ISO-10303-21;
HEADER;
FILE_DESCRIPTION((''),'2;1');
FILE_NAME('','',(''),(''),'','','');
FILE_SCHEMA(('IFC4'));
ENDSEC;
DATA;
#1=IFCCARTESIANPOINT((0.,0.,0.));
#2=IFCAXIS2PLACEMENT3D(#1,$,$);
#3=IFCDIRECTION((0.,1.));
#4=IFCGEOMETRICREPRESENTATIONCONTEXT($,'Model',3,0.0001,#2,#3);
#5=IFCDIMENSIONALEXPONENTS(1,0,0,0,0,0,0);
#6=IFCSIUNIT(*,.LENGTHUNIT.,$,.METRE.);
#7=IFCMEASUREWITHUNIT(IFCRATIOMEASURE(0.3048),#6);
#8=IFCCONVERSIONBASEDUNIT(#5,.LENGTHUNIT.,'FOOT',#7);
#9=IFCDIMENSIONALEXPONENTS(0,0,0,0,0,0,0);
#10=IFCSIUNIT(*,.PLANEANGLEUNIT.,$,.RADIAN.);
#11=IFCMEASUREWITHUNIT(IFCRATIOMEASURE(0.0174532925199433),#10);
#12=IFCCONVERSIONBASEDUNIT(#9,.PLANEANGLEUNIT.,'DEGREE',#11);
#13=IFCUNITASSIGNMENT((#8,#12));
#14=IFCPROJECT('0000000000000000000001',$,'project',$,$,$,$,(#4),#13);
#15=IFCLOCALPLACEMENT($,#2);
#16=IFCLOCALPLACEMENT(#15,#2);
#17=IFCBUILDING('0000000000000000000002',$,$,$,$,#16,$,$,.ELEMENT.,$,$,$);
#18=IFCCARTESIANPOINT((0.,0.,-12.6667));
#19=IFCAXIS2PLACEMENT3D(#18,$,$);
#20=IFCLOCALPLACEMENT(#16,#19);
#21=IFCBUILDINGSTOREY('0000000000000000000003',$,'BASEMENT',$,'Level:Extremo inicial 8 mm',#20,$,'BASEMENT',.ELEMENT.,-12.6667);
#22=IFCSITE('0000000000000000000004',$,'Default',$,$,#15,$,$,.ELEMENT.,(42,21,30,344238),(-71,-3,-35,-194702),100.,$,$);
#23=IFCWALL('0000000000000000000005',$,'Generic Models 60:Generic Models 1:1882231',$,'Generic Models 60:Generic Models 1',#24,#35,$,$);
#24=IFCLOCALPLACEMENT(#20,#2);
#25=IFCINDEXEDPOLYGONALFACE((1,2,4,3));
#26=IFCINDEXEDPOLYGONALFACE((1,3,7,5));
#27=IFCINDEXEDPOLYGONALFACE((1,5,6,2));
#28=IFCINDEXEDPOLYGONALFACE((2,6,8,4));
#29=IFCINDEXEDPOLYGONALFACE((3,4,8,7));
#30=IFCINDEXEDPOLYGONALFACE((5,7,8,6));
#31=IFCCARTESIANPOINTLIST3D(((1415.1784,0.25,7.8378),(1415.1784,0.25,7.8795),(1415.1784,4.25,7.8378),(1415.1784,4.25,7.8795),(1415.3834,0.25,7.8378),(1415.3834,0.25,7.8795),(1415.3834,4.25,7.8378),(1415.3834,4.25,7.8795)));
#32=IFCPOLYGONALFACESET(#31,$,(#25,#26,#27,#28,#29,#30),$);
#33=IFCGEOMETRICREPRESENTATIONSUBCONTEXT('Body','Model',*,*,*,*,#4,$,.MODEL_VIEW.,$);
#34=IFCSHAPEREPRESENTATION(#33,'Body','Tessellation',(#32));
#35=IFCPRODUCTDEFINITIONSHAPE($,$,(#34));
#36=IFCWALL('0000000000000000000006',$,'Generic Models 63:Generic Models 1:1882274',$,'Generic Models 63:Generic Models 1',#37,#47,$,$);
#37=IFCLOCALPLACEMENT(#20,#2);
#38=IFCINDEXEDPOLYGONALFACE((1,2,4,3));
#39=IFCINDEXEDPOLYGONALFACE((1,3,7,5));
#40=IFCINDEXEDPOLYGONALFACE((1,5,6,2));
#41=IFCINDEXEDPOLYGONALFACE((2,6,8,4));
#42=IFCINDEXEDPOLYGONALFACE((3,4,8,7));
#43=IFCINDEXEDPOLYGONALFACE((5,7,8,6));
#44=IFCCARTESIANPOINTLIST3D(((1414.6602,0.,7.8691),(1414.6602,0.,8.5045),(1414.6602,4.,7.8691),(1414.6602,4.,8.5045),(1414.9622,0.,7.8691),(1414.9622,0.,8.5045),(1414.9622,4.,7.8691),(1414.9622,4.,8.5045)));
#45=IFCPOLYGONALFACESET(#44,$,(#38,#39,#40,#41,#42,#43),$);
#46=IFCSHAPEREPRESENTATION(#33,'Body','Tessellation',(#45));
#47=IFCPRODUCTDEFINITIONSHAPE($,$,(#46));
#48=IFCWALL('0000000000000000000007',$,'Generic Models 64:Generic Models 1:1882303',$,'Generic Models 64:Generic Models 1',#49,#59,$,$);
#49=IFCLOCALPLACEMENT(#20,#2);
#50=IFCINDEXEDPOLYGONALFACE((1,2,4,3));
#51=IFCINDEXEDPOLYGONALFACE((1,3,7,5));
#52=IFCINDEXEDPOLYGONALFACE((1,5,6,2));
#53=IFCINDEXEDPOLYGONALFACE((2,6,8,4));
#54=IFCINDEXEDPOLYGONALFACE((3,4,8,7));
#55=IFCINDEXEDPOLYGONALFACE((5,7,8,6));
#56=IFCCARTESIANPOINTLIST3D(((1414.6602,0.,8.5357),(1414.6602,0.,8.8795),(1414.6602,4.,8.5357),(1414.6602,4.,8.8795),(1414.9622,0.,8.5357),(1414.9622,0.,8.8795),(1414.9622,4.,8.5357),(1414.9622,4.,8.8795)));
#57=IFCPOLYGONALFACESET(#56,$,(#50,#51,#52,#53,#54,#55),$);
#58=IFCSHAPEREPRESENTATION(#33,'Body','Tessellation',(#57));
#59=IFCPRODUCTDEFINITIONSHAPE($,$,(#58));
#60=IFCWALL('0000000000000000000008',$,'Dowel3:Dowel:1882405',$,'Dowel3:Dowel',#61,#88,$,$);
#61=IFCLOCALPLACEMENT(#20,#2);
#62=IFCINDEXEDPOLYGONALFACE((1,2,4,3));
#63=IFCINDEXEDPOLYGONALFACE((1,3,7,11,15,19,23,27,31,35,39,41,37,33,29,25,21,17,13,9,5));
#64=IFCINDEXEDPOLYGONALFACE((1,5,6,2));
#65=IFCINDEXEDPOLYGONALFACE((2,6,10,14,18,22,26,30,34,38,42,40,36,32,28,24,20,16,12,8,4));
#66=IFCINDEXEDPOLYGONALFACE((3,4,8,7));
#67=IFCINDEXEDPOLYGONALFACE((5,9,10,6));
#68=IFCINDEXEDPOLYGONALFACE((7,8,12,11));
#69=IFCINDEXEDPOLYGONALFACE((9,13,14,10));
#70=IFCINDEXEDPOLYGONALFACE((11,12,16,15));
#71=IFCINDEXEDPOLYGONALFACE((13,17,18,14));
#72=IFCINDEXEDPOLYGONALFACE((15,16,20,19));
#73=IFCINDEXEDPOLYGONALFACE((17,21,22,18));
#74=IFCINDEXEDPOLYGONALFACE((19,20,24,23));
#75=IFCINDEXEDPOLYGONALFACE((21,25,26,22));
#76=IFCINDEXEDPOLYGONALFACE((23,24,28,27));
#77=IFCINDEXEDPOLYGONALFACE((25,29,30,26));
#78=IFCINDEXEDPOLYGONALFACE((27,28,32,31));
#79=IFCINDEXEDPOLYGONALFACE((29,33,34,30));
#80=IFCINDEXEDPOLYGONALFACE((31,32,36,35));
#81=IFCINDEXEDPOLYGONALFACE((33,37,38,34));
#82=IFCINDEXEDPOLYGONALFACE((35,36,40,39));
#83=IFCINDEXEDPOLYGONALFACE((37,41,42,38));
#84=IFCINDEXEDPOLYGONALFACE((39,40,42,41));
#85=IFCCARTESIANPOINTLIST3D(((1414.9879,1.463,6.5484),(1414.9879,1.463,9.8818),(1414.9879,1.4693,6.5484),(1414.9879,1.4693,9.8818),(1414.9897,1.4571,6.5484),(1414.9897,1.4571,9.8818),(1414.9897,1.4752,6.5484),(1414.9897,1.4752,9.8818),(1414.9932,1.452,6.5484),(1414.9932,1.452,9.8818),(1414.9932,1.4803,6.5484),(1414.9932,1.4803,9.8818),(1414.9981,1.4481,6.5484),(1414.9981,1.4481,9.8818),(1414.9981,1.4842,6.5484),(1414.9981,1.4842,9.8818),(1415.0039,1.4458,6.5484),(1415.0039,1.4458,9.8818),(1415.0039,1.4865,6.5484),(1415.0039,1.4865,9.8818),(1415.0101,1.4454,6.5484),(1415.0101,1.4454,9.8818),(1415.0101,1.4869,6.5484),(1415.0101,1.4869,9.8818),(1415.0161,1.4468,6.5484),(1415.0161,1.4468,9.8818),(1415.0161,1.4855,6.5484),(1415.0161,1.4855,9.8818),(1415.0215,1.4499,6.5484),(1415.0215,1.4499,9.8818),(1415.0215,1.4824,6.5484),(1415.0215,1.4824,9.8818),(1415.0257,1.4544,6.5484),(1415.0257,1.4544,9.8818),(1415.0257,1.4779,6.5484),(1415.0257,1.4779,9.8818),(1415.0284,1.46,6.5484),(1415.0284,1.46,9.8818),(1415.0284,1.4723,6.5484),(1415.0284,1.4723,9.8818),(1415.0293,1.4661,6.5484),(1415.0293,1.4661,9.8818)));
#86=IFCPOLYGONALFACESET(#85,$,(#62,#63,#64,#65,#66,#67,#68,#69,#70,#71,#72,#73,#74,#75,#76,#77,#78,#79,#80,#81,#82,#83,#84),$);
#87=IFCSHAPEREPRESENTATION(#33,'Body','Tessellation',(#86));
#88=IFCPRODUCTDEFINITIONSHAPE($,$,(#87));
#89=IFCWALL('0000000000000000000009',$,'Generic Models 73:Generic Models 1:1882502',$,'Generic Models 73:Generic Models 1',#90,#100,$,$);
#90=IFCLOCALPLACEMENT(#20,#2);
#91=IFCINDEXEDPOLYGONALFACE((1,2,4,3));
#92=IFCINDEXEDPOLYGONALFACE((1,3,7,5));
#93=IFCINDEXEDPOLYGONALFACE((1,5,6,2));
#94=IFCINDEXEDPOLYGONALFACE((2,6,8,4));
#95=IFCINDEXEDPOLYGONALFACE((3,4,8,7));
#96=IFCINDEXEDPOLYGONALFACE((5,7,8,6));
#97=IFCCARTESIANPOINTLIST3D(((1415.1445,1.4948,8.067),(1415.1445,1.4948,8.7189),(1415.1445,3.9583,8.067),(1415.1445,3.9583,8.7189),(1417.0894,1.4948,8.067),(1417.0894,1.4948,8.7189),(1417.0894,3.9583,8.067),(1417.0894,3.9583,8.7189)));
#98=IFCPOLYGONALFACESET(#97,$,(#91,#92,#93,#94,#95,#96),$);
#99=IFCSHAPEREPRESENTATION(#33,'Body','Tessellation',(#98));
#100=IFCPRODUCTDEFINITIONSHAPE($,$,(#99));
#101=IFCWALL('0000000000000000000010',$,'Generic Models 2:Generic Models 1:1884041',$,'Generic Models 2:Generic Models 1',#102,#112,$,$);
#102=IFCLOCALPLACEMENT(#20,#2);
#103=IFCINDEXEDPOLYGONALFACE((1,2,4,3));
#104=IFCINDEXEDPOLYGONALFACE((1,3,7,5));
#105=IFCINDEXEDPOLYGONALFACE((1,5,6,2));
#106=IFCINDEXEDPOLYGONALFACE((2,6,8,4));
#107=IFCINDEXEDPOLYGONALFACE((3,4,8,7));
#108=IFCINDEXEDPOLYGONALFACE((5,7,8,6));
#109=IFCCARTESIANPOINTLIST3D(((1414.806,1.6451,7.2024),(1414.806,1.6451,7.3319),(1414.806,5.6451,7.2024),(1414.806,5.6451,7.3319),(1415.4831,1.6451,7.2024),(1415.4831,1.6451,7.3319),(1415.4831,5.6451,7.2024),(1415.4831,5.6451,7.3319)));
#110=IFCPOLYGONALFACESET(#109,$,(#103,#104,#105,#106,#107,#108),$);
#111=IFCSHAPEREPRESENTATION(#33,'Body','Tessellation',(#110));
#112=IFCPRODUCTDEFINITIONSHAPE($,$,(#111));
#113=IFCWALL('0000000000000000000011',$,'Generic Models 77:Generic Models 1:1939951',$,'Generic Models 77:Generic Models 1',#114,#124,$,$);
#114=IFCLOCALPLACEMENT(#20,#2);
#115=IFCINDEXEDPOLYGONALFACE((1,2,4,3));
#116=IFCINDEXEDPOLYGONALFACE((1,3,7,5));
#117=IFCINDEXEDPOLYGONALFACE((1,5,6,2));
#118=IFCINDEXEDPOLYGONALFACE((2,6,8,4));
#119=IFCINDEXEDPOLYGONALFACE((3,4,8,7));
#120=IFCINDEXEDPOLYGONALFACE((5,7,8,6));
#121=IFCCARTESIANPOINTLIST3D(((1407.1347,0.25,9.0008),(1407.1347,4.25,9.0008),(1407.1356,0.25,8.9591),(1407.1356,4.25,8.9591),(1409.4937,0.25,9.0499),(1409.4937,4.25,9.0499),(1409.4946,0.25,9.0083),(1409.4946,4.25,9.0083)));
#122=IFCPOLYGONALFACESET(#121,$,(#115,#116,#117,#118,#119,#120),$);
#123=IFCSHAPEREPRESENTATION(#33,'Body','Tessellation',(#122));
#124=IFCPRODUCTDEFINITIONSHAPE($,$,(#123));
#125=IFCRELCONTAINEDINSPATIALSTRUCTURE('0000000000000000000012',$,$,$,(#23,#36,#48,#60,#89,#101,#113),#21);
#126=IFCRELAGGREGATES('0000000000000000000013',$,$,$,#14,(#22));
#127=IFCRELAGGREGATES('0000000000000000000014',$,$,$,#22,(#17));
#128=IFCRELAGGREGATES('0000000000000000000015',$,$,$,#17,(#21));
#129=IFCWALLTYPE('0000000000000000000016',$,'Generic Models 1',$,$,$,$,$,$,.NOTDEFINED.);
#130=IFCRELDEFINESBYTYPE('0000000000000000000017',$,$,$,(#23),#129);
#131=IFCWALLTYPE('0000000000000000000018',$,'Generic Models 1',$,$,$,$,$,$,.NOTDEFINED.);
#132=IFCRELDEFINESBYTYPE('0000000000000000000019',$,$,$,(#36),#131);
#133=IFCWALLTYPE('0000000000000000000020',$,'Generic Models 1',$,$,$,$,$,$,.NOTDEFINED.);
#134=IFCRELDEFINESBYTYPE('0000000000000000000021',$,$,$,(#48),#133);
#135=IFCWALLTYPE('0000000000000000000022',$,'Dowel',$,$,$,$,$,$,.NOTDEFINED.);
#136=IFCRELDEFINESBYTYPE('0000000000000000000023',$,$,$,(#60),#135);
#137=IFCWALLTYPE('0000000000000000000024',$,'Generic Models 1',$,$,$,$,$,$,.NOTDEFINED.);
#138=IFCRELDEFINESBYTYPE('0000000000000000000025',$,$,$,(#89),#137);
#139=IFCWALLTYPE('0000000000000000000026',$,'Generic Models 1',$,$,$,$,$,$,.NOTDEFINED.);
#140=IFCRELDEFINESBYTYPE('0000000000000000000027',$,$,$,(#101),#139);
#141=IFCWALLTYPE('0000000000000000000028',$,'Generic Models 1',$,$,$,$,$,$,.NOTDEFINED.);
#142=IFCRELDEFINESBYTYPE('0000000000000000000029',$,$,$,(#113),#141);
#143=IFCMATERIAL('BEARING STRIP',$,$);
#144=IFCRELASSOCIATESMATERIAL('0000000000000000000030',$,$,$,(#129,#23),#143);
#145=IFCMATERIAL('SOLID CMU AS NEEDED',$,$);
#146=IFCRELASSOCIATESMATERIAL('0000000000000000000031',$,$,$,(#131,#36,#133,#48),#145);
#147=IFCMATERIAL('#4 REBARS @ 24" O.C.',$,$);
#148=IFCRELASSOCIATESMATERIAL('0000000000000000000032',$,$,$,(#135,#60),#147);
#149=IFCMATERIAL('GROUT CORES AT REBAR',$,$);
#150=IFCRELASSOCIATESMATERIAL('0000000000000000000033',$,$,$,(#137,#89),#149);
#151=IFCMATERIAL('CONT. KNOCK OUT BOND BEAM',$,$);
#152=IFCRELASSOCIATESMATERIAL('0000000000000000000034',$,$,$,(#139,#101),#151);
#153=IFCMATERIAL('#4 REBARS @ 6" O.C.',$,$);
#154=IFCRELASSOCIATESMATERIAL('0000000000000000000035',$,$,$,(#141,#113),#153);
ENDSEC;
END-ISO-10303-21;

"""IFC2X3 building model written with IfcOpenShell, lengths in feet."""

from ifc_helpers import new_model, entity, si_unit, converted_unit, direction, frame, frame_2d, origin, origin_2d_with_axis, place, context, subcontext, project, spatial, rectangle, circle, extrude, material, type_object, element, save


model = new_model("IFC2X3")

# Units and contexts
model_context = context("Model", 3, precision=0.0001, world=origin(), true_north=direction((0.0, 1.0)))
body_context = subcontext(model_context, "Body", "Model", "MODEL_VIEW")
ifc_project = project(units=[converted_unit("LENGTHUNIT", "FOOT", entity("IfcRatioMeasure", 0.3048), si_unit("LENGTHUNIT", "METRE"), dimensions=[1, 0, 0, 0, 0, 0, 0]), converted_unit("PLANEANGLEUNIT", "DEGREE", entity("IfcRatioMeasure", 0.0174532925199433), si_unit("PLANEANGLEUNIT", "RADIAN"), dimensions=[0, 0, 0, 0, 0, 0, 0])], contexts=[model_context])

# Site, building, storey
site_placement = place(None, origin())
site = spatial("IfcSite", under=ifc_project, at=site_placement, Name="Default", CompositionType="ELEMENT", RefLatitude=(42, 21, 30, 344238), RefLongitude=(-71, -3, -35, -194702), RefElevation=100.0)
building_placement = place(site_placement, origin())
building = spatial("IfcBuilding", under=site, at=building_placement, CompositionType="ELEMENT")
storey_placement = place(building_placement, frame((0.0, 0.0, -12.6667)))
storey = spatial("IfcBuildingStorey", under=building, at=storey_placement, Name="BASEMENT", ObjectType="Level:Extremo inicial 8 mm", LongName="BASEMENT", CompositionType="ELEMENT", Elevation=-12.6667)

# Wall
ifc_material_1 = material(Name="BEARING STRIP")
wall_type_1 = type_object("IfcWallType", Name="Generic Models 1", PredefinedType="NOTDEFINED", material=ifc_material_1)
wall_1_placement = place(storey_placement, frame((1415.1784, 0.25, 7.8378), z_axis=(0.0, 0.0, 1.0), x_axis=(0.0, 1.0, 0.0)))
element("IfcWall", 1, at=wall_1_placement, inside=storey, type_object=wall_type_1, material=ifc_material_1, Name="Generic Models 60:Generic Models 1:1882231", ObjectType="Generic Models 60:Generic Models 1", context=body_context, shape_type="SweptSolid", body=[
    extrude(rectangle(XDim=4.0, YDim=0.205, at=frame_2d((0.0, 0.0), x_axis=(1.0, 0.0))), frame((2.0, -0.1025, 0.0)), (0.0, 0.0, 1.0), 0.0417),
])

# Walls
ifc_material_2 = material(Name="SOLID CMU AS NEEDED")
wall_type_2 = type_object("IfcWallType", Name="Generic Models 1", PredefinedType="NOTDEFINED", material=ifc_material_2)
wall_2_placement = place(storey_placement, frame((1414.6602, 0.0, 7.8691), z_axis=(0.0, 0.0, 1.0), x_axis=(0.0, 1.0, 0.0)))
element("IfcWall", 2, at=wall_2_placement, inside=storey, type_object=wall_type_2, material=ifc_material_2, Name="Generic Models 63:Generic Models 1:1882274", ObjectType="Generic Models 63:Generic Models 1", context=body_context, shape_type="SweptSolid", body=[
    extrude(rectangle(XDim=4.0, YDim=0.3021, at=frame_2d((0.0, 0.0), x_axis=(1.0, 0.0))), frame((2.0, -0.151, 0.0), z_axis=(0.0, 0.0, 1.0), x_axis=(-1.0, 0.0, 0.0)), (0.0, 0.0, 1.0), 0.6354),
])
wall_type_3 = type_object("IfcWallType", Name="Generic Models 1", PredefinedType="NOTDEFINED", material=ifc_material_2)
wall_3_placement = place(storey_placement, frame((1414.6602, 0.0, 8.5357), z_axis=(0.0, 0.0, 1.0), x_axis=(0.0, 1.0, 0.0)))
element("IfcWall", 3, at=wall_3_placement, inside=storey, type_object=wall_type_3, material=ifc_material_2, Name="Generic Models 64:Generic Models 1:1882303", ObjectType="Generic Models 64:Generic Models 1", context=body_context, shape_type="SweptSolid", body=[
    extrude(rectangle(XDim=4.0, YDim=0.3021, at=frame_2d((0.0, 0.0), x_axis=(1.0, 0.0))), frame((2.0, -0.151, 0.0), z_axis=(0.0, 0.0, 1.0), x_axis=(-1.0, 0.0, 0.0)), (0.0, 0.0, 1.0), 0.3437),
])

# Wall
ifc_material_3 = material(Name="#4 REBARS @ 24\" O.C.")
wall_type_4 = type_object("IfcWallType", Name="Dowel", PredefinedType="NOTDEFINED", material=ifc_material_3)
wall_4_placement = place(storey_placement, frame((1414.9877, 1.4453, 6.5484), z_axis=(0.0, 0.0, 1.0), x_axis=(0.0, 1.0, 0.0)))
element("IfcWall", 4, at=wall_4_placement, inside=storey, type_object=wall_type_4, material=ifc_material_3, Name="Dowel3:Dowel:1882405", ObjectType="Dowel3:Dowel", context=body_context, shape_type="SweptSolid", body=[
    extrude(circle(Radius=0.0208, at=origin_2d_with_axis()), frame((0.0208, -0.0208, 0.0), z_axis=(0.0, 0.0, 1.0), x_axis=(0.0, -1.0, 0.0)), (0.0, 0.0, 1.0), 3.3333),
])

# Shared definitions
ifc_material_4 = material(Name="CONT. KNOCK OUT BOND BEAM")

# Walls
ifc_material_5 = material(Name="GROUT CORES AT REBAR")
wall_type_5 = type_object("IfcWallType", Name="Generic Models 1", PredefinedType="NOTDEFINED", material=ifc_material_5)
wall_5_placement = place(storey_placement, frame((1415.1445, 1.4948, 8.067), z_axis=(0.0, 0.0, 1.0), x_axis=(0.0, 1.0, 0.0)))
element("IfcWall", 5, at=wall_5_placement, inside=storey, type_object=wall_type_5, material=ifc_material_5, Name="Generic Models 73:Generic Models 1:1882502", ObjectType="Generic Models 73:Generic Models 1", context=body_context, shape_type="SweptSolid", body=[
    extrude(rectangle(XDim=2.4635, YDim=1.9448, at=frame_2d((0.0, 0.0), x_axis=(1.0, 0.0))), frame((1.2318, -0.9724, 0.0)), (0.0, 0.0, 1.0), 0.6519),
])
wall_type_6 = type_object("IfcWallType", Name="Generic Models 1", PredefinedType="NOTDEFINED", material=ifc_material_4)
wall_6_placement = place(storey_placement, frame((1414.806, 1.6451, 7.2024), z_axis=(0.0, 0.0, 1.0), x_axis=(0.0, 1.0, 0.0)))
element("IfcWall", 6, at=wall_6_placement, inside=storey, type_object=wall_type_6, material=ifc_material_4, Name="Generic Models 2:Generic Models 1:1884041", ObjectType="Generic Models 2:Generic Models 1", context=body_context, shape_type="SweptSolid", body=[
    extrude(rectangle(XDim=4.0, YDim=0.6771, at=origin_2d_with_axis()), frame((2.0, -0.3385, 0.0)), (0.0, 0.0, 1.0), 0.1295),
])
ifc_material_6 = material(Name="#4 REBARS @ 6\" O.C.")
wall_type_7 = type_object("IfcWallType", Name="Generic Models 1", PredefinedType="NOTDEFINED", material=ifc_material_6)
wall_7_placement = place(storey_placement, frame((1407.1347, 0.25, 8.9591), z_axis=(0.0, 0.0, 1.0), x_axis=(0.0, 1.0, 0.0)))
element("IfcWall", 7, at=wall_7_placement, inside=storey, type_object=wall_type_7, material=ifc_material_6, Name="Generic Models 77:Generic Models 1:1939951", ObjectType="Generic Models 77:Generic Models 1", context=body_context, shape_type="SweptSolid", body=[
    extrude(rectangle(XDim=2.3596, YDim=4.0, at=frame_2d((0.0, 0.0), x_axis=(0.0, 1.0))), frame((2.0, -1.1804, 0.0246), z_axis=(0.0, 0.020829, 0.999783), x_axis=(1.0, 0.0, 0.0)), (0.0, 0.0, 1.0), 0.0417),
])

save(model, "model.ifc")
